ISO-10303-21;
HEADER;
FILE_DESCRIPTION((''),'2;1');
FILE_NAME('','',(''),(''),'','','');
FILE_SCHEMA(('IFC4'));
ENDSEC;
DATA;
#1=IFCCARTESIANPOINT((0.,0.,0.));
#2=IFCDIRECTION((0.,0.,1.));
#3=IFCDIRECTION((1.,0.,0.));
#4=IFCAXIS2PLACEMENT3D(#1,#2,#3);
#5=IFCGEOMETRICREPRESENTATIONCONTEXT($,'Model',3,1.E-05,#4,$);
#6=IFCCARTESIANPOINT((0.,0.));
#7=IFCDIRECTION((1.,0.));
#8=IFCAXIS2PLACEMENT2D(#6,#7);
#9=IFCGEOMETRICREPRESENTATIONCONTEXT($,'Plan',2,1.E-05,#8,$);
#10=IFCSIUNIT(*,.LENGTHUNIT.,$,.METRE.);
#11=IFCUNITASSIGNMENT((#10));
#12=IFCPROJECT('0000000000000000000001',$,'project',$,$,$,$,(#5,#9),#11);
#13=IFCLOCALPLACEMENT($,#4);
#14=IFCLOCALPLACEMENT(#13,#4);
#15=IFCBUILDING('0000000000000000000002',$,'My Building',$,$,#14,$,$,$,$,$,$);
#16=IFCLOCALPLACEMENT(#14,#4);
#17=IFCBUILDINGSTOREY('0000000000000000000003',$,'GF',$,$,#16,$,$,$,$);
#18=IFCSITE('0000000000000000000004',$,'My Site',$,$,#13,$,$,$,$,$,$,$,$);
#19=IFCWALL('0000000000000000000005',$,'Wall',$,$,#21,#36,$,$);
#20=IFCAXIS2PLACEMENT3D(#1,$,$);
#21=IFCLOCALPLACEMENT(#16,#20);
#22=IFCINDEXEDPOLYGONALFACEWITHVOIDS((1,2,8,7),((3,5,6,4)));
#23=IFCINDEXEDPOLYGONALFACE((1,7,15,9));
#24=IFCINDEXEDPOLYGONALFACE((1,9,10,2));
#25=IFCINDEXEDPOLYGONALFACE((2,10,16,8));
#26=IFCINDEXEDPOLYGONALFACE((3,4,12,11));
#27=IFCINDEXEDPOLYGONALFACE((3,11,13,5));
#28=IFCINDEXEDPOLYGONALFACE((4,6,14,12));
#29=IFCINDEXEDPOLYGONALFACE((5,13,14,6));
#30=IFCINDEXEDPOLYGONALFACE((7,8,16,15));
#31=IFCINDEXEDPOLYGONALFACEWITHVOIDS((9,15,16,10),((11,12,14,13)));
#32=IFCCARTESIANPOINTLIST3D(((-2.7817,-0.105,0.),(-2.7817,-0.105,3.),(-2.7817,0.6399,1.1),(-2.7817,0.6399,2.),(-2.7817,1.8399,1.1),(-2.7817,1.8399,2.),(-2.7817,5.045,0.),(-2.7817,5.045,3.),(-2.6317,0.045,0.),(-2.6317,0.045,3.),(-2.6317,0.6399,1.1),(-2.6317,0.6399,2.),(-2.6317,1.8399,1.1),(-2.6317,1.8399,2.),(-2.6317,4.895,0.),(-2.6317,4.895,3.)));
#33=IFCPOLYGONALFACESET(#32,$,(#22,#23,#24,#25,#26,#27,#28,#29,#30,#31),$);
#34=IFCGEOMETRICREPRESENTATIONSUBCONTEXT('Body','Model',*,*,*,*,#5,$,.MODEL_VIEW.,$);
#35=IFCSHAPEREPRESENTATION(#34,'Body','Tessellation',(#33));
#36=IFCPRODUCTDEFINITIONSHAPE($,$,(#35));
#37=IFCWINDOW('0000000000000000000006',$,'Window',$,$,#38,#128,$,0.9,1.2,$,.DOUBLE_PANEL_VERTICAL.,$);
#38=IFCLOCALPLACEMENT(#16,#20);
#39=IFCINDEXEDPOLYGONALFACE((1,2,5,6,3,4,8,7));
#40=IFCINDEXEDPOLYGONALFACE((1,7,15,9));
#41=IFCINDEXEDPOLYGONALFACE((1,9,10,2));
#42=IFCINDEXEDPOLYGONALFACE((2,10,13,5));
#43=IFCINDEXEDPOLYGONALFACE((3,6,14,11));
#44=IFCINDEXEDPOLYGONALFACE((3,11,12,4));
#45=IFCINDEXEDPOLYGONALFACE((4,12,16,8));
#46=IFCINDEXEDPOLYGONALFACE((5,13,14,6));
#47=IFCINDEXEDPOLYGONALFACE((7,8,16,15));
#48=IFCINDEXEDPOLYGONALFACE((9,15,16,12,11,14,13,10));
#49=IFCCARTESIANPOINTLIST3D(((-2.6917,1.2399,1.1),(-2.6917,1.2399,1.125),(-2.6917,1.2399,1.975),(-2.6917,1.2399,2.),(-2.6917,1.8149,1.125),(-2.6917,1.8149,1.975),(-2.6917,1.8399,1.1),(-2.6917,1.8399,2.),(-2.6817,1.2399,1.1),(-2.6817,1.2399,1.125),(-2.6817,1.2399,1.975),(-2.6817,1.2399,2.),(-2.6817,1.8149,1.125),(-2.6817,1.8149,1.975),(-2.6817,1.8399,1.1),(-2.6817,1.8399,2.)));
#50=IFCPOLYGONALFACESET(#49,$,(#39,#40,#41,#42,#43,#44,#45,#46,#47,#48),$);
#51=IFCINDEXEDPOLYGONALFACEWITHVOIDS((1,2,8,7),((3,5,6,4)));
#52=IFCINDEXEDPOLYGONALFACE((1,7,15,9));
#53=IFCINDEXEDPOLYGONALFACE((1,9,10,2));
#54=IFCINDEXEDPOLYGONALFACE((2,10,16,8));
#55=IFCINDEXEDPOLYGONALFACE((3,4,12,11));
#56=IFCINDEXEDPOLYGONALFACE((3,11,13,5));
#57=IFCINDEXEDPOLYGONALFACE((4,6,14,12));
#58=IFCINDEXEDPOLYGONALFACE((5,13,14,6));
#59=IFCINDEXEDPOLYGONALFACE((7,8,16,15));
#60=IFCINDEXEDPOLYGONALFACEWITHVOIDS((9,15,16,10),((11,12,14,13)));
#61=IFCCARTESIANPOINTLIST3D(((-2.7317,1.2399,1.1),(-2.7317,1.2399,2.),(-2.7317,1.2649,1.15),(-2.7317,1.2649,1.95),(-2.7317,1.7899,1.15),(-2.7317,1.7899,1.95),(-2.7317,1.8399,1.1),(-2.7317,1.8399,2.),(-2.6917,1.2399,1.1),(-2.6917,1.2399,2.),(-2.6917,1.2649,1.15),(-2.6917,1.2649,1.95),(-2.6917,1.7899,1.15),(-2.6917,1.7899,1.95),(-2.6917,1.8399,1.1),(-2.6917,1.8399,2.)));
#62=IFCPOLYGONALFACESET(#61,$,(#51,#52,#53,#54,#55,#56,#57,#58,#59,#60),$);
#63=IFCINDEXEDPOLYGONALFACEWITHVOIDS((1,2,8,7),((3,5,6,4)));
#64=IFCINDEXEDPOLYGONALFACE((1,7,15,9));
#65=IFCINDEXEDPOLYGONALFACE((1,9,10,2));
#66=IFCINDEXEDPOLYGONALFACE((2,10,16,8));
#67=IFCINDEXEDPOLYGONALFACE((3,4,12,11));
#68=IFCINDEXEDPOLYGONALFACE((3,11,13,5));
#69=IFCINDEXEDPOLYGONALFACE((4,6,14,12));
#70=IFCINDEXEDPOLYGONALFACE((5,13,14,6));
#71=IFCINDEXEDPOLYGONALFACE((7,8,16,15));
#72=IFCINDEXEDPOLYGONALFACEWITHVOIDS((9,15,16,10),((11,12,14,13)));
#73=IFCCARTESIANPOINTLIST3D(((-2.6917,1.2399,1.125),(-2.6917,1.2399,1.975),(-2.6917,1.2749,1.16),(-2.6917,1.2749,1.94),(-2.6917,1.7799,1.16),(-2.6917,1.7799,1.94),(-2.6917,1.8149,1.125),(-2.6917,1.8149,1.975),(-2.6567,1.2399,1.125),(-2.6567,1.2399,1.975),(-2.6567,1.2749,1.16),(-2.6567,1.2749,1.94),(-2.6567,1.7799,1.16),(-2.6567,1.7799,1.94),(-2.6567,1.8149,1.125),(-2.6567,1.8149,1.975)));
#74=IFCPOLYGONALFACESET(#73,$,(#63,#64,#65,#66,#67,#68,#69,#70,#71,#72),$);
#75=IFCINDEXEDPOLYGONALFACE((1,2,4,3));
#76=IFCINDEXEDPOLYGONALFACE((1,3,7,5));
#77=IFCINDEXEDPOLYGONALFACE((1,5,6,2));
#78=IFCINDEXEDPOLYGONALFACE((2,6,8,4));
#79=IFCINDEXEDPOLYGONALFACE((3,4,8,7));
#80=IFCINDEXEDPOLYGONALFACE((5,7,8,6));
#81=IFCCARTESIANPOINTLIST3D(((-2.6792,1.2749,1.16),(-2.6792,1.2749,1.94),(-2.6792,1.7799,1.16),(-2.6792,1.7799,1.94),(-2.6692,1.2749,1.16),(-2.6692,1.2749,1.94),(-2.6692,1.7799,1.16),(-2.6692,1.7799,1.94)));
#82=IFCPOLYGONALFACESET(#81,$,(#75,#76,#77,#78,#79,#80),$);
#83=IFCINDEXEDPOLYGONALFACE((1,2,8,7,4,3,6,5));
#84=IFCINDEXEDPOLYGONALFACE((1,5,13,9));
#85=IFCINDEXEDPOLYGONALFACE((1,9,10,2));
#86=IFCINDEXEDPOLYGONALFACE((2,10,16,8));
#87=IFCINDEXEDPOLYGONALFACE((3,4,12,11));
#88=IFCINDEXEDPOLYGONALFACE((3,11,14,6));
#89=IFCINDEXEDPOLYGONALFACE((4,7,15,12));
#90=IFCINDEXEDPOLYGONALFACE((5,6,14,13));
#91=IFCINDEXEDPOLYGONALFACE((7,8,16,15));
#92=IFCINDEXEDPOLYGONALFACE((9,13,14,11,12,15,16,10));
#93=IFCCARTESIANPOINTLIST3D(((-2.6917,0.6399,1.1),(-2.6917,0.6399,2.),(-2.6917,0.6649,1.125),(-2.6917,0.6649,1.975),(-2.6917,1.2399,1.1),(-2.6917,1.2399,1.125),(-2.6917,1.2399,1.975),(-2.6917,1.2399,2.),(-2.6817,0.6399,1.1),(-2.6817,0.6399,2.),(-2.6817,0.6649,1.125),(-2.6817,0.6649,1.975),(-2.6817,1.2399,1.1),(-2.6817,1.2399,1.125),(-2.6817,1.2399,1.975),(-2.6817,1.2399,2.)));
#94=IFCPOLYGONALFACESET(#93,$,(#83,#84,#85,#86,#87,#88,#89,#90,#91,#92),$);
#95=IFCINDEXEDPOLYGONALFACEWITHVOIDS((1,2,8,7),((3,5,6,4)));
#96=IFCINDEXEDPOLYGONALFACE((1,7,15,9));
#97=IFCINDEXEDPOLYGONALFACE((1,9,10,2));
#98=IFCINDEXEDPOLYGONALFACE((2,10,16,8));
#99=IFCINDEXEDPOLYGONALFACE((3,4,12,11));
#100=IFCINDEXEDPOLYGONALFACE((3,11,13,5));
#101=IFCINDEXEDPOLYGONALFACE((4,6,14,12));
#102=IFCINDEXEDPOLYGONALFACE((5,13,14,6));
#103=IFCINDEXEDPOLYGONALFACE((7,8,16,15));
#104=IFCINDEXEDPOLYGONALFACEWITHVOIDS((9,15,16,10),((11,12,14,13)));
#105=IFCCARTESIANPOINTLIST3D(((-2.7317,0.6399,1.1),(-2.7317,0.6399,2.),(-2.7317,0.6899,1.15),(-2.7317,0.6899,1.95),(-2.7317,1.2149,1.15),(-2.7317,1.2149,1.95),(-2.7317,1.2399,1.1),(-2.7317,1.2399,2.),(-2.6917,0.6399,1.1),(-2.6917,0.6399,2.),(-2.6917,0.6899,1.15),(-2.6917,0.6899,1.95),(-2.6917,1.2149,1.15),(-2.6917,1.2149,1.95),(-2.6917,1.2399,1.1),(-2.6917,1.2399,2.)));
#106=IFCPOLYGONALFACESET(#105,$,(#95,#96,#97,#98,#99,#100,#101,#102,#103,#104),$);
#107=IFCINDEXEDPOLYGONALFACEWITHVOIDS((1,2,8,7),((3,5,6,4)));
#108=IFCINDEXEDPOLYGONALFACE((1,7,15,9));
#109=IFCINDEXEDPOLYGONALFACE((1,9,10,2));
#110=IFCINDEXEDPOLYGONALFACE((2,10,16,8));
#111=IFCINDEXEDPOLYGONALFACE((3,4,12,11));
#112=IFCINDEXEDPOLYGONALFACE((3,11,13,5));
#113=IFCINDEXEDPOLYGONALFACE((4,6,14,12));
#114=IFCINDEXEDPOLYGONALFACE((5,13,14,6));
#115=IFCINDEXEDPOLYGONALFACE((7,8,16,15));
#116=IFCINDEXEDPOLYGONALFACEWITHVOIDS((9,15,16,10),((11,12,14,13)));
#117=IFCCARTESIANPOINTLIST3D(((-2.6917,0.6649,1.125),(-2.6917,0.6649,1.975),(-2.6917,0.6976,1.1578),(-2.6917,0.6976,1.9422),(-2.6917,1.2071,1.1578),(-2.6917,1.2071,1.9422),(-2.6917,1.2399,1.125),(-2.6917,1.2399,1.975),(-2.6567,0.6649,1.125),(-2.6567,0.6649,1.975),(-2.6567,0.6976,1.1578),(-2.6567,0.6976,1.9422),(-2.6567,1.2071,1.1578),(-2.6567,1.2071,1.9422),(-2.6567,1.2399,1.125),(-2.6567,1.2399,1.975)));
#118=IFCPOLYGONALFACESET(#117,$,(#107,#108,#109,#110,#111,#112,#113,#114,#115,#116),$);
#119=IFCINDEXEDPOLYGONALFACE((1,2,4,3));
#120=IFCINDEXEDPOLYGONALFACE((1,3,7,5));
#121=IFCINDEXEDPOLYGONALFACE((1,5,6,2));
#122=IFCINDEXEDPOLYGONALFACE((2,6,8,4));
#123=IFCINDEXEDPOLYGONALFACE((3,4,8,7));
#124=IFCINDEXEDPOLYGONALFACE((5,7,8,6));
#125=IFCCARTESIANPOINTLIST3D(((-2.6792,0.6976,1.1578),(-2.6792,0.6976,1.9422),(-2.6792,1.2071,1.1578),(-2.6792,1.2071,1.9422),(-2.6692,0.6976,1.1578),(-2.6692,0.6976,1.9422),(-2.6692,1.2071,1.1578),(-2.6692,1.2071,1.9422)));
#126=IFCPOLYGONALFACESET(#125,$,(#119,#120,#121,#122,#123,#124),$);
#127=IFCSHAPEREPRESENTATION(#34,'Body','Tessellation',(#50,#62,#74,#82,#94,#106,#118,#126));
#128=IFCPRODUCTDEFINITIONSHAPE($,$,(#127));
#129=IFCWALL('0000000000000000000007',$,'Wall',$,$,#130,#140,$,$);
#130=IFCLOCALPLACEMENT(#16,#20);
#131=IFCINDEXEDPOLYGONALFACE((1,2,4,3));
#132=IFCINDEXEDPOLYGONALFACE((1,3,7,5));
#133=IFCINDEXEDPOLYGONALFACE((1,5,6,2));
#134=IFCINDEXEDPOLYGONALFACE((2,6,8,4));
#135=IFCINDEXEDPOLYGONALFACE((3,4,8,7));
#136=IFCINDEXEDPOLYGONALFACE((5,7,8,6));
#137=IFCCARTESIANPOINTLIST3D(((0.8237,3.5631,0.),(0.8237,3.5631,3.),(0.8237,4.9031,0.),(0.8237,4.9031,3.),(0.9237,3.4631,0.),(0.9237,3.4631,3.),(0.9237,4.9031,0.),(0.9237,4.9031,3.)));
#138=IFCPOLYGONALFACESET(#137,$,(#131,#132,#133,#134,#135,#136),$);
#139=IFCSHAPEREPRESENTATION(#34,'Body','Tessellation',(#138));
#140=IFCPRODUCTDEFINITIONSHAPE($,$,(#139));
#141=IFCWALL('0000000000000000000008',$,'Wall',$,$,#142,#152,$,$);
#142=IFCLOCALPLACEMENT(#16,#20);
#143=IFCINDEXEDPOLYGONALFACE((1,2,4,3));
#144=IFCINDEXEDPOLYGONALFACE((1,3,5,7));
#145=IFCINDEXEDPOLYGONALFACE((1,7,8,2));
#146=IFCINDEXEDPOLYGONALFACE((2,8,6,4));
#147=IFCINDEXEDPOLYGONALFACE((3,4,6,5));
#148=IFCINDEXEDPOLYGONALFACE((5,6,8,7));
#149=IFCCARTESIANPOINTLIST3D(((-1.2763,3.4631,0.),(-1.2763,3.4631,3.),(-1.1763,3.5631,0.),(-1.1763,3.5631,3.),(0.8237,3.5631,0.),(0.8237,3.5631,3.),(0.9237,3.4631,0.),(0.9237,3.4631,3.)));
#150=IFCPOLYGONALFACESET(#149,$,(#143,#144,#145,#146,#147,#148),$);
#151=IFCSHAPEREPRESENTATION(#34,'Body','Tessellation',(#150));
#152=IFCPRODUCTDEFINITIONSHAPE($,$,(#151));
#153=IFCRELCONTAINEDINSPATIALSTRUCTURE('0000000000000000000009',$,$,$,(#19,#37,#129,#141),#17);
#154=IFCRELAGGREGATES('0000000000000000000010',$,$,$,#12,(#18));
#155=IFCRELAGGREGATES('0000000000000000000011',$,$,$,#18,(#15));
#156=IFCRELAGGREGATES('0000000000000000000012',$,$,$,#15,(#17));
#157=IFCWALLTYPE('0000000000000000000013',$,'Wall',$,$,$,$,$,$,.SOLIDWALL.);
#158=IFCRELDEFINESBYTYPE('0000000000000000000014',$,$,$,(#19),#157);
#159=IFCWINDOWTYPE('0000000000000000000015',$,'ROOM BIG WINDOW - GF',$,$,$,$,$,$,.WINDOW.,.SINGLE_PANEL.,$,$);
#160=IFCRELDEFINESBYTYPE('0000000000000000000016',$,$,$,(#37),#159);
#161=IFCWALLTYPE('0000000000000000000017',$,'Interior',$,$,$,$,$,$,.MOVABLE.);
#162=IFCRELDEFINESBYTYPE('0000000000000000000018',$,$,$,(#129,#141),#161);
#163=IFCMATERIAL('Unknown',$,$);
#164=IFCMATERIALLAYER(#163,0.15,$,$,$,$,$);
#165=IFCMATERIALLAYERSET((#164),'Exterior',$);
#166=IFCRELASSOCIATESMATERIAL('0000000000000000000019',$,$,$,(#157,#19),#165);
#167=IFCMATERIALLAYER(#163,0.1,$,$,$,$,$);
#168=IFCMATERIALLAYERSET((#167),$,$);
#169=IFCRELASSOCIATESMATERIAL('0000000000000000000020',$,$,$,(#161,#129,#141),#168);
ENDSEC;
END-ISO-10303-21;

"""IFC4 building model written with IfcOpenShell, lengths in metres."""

from ifc_helpers import new_model, entity, si_unit, frame, origin_with_axes, origin_2d_with_axis, place, context, subcontext, project, spatial, line, indexed_curve, outline, extrude, shape, source, transform, mapped, material, layer, layer_set, layer_usage, type_object, type_shapes, element, fill, save


model = new_model("IFC4")

# Units and contexts
model_context = context("Model", 3, precision=1e-05, world=origin_with_axes())
plan_context = context("Plan", 2, precision=1e-05, world=origin_2d_with_axis())
body_context_1 = subcontext(model_context, "Body", "Model", "MODEL_VIEW")
body_context_2 = subcontext(plan_context, "Body", "Plan", "PLAN_VIEW")
ifc_project = project(units=[si_unit("LENGTHUNIT", "METRE")], contexts=[model_context, plan_context])

# Site, building, storey
site_placement = place(None, origin_with_axes())
site = spatial("IfcSite", under=ifc_project, at=site_placement, Name="My Site")
building_placement = place(site_placement, origin_with_axes())
building = spatial("IfcBuilding", under=site, at=building_placement, Name="My Building")
storey_placement = place(building_placement, origin_with_axes())
storey = spatial("IfcBuildingStorey", under=building, at=storey_placement, Name="GF")

# Shared definitions
ifc_material = material(Name="Unknown")

# Shared definitions
ifc_layer_1 = layer(ifc_material, 0.15)
ifc_layer_set_1 = layer_set([ifc_layer_1], Name="Exterior")
wall_type_1 = type_object("IfcWallType", Name="Wall", PredefinedType="SOLIDWALL", material=ifc_layer_set_1)

# Wall, opening, window
ifc_layer_usage_1 = layer_usage(ifc_layer_set_1, "AXIS2", "POSITIVE", 0.0)
wall_1_placement = place(storey_placement, frame((-2.7817, 5.045, 0.0), z_axis=(0.0, 0.0, 1.0), x_axis=(0.0, -1.0, 0.0)))
wall_1 = element("IfcWall", 1, at=wall_1_placement, inside=storey, type_object=wall_type_1, material=ifc_layer_usage_1, Name="Wall", context=body_context_1, shape_type="SweptSolid", body=[
    extrude(outline(indexed_curve([(0.0, 0.0), (0.15, 0.15), (5.0, 0.15), (5.15, 0.0)], segments=[line(1, 2, 3, 4, 1)])), origin_with_axes(), (0.0, 0.0, 1.0), 3.0),
])
shared_shape_1 = source(origin_with_axes(), body_context_1, "Body", "SweptSolid", [
    extrude(outline(indexed_curve([(0.0, 0.0), (1.2, 0.0), (1.2, 0.9), (0.0, 0.9)], segments=[line(1, 2, 3, 4, 1)])), frame((0.0, -0.6, 0.0), z_axis=(0.0, -1.0, 0.0), x_axis=(1.0, 0.0, 0.0)), (0.0, 0.0, -1.0), 1.2),
])
opening_1_placement = place(wall_1_placement, frame((3.2051, 0.0, 1.1), z_axis=(0.0, 0.0, 1.0), x_axis=(1.0, 0.0, 0.0)))
opening_1 = element("IfcOpeningElement", 2, at=opening_1_placement, cuts=wall_1, PredefinedType="OPENING", context=body_context_1, shape_type="MappedRepresentation", body=[
    mapped(shared_shape_1, transform((0.0, 0.0, 0.0), x_axis=(1.0, 0.0, 0.0), y_axis=(0.0, 1.0, 0.0), z_axis=(0.0, 0.0, 1.0), scale=1.0)),
])
window_type_1 = type_object("IfcWindowType", Name="ROOM BIG WINDOW - GF", PartitioningType="SINGLE_PANEL", PredefinedType="WINDOW")
shared_shape_2 = source(origin_with_axes(), body_context_1, "Body", "SweptSolid", [
    extrude(outline(indexed_curve([(0.6, 0.0), (0.0, 0.0), (0.0, 0.9), (0.6, 0.9), (0.6, 0.875), (0.025, 0.875), (0.025, 0.025), (0.6, 0.025)], segments=[line(1, 2, 3, 4, 5, 6, 7, 8, 1)])), frame((0.0, 0.09, 0.0), z_axis=(0.0, -1.0, 0.0), x_axis=(1.0, 0.0, 0.0)), (0.0, 0.0, -1.0), 0.01),
    extrude(outline(indexed_curve([(0.0, 0.0), (0.6, 0.0), (0.6, 0.9), (0.0, 0.9)], segments=[line(1, 2, 3, 4, 1)]), holes=[indexed_curve([(0.05, 0.05), (0.575, 0.05), (0.575, 0.85), (0.05, 0.85)], segments=[line(1, 2, 3, 4, 1)])]), frame((0.0, 0.05, 0.0), z_axis=(0.0, -1.0, 0.0), x_axis=(1.0, 0.0, 0.0)), (0.0, 0.0, -1.0), 0.04),
    extrude(outline(indexed_curve([(0.0, 0.0), (0.575, 0.0), (0.575, 0.85), (0.0, 0.85)], segments=[line(1, 2, 3, 4, 1)]), holes=[indexed_curve([(0.035, 0.035), (0.54, 0.035), (0.54, 0.815), (0.035, 0.815)], segments=[line(1, 2, 3, 4, 1)])]), frame((0.025, 0.09, 0.025), z_axis=(0.0, -1.0, 0.0), x_axis=(1.0, 0.0, 0.0)), (0.0, 0.0, -1.0), 0.035),
    extrude(outline(indexed_curve([(0.035, 0.035), (0.54, 0.035), (0.54, 0.815), (0.035, 0.815)], segments=[line(1, 2, 3, 4, 1)])), frame((0.025, 0.1025, 0.025), z_axis=(0.0, -1.0, 0.0), x_axis=(1.0, 0.0, 0.0)), (0.0, 0.0, -1.0), 0.01),
    extrude(outline(indexed_curve([(0.0, 0.9), (0.6, 0.9), (0.6, 0.0), (0.0, 0.0), (0.0, 0.025), (0.575, 0.025), (0.575, 0.875), (0.0, 0.875)], segments=[line(1, 2, 3, 4, 5, 6, 7, 8, 1)])), frame((0.6, 0.09, 0.0), z_axis=(0.0, -1.0, 0.0), x_axis=(1.0, 0.0, 0.0)), (0.0, 0.0, -1.0), 0.01),
    extrude(outline(indexed_curve([(0.0, 0.0), (0.6, 0.0), (0.6, 0.9), (0.0, 0.9)], segments=[line(1, 2, 3, 4, 1)]), holes=[indexed_curve([(0.025, 0.05), (0.55, 0.05), (0.55, 0.85), (0.025, 0.85)], segments=[line(1, 2, 3, 4, 1)])]), frame((0.6, 0.05, 0.0), z_axis=(0.0, -1.0, 0.0), x_axis=(1.0, 0.0, 0.0)), (0.0, 0.0, -1.0), 0.04),
    extrude(outline(indexed_curve([(0.0, 0.0), (0.575, 0.0), (0.575, 0.85), (0.0, 0.85)], segments=[line(1, 2, 3, 4, 1)]), holes=[indexed_curve([(0.0328, 0.0328), (0.5422, 0.0328), (0.5422, 0.8172), (0.0328, 0.8172)], segments=[line(1, 2, 3, 4, 1)])]), frame((0.6, 0.09, 0.025), z_axis=(0.0, -1.0, 0.0), x_axis=(1.0, 0.0, 0.0)), (0.0, 0.0, -1.0), 0.035),
    extrude(outline(indexed_curve([(0.0328, 0.0328), (0.5422, 0.0328), (0.5422, 0.8172), (0.0328, 0.8172)], segments=[line(1, 2, 3, 4, 1)])), frame((0.6, 0.1025, 0.025), z_axis=(0.0, -1.0, 0.0), x_axis=(1.0, 0.0, 0.0)), (0.0, 0.0, -1.0), 0.01),
])
shared_shape_3 = source(origin_with_axes(), body_context_2, "Body", "Curve2D", [
    entity("IfcIndexedPolyCurve", entity("IfcCartesianPointList2D", [[0.05, 0.05], [0.575, 0.05]])),
    entity("IfcIndexedPolyCurve", entity("IfcCartesianPointList2D", [[0.0, 0.1], [0.025, 0.1], [0.025, 0.09], [0.05, 0.09], [0.05, 0.05], [0.0, 0.05]]), [entity("IfcLineIndex", [1, 2, 3, 4, 5, 6, 1])]),
    entity("IfcIndexedPolyCurve", entity("IfcCartesianPointList2D", [[0.6, 0.1], [0.6, 0.1], [0.6, 0.09], [0.575, 0.09], [0.575, 0.05], [0.6, 0.05]])),
    entity("IfcIndexedPolyCurve", entity("IfcCartesianPointList2D", [[0.025, 0.09], [0.06, 0.09], [0.06, 0.125], [0.025, 0.125]]), [entity("IfcLineIndex", [1, 2, 3, 4, 1])]),
    entity("IfcIndexedPolyCurve", entity("IfcCartesianPointList2D", [[0.6, 0.09], [0.565, 0.09], [0.565, 0.125], [0.6, 0.125]]), [entity("IfcLineIndex", [1, 2, 3, 4, 1])]),
    entity("IfcIndexedPolyCurve", entity("IfcCartesianPointList2D", [[0.06, 0.09], [0.565, 0.09]])),
    entity("IfcIndexedPolyCurve", entity("IfcCartesianPointList2D", [[0.06, 0.125], [0.565, 0.125]])),
    entity("IfcIndexedPolyCurve", entity("IfcCartesianPointList2D", [[0.06, 0.1075], [0.565, 0.1075]])),
    entity("IfcIndexedPolyCurve", entity("IfcCartesianPointList2D", [[0.625, 0.05], [1.15, 0.05]])),
    entity("IfcIndexedPolyCurve", entity("IfcCartesianPointList2D", [[0.6, 0.1], [0.6, 0.1], [0.6, 0.09], [0.625, 0.09], [0.625, 0.05], [0.6, 0.05]])),
    entity("IfcIndexedPolyCurve", entity("IfcCartesianPointList2D", [[1.2, 0.1], [1.175, 0.1], [1.175, 0.09], [1.15, 0.09], [1.15, 0.05], [1.2, 0.05]]), [entity("IfcLineIndex", [1, 2, 3, 4, 5, 6, 1])]),
    entity("IfcIndexedPolyCurve", entity("IfcCartesianPointList2D", [[0.6, 0.09], [0.6328, 0.09], [0.6328, 0.125], [0.6, 0.125]]), [entity("IfcLineIndex", [1, 2, 3, 4, 1])]),
    entity("IfcIndexedPolyCurve", entity("IfcCartesianPointList2D", [[1.175, 0.09], [1.1422, 0.09], [1.1422, 0.125], [1.175, 0.125]]), [entity("IfcLineIndex", [1, 2, 3, 4, 1])]),
    entity("IfcIndexedPolyCurve", entity("IfcCartesianPointList2D", [[0.6328, 0.09], [1.1422, 0.09]])),
    entity("IfcIndexedPolyCurve", entity("IfcCartesianPointList2D", [[0.6328, 0.125], [1.1422, 0.125]])),
    entity("IfcIndexedPolyCurve", entity("IfcCartesianPointList2D", [[0.6328, 0.1075], [1.1422, 0.1075]])),
])
type_shapes(window_type_1, [shared_shape_2, shared_shape_3])
window_1_placement = place(opening_1_placement, frame((0.0, 0.0, 0.0), z_axis=(0.0, 0.0, 1.0), x_axis=(1.0, 0.0, 0.0)))
window_1 = element("IfcWindow", 3, at=window_1_placement, inside=storey, type_object=window_type_1, Name="Window", OverallHeight=0.9, OverallWidth=1.2, PartitioningType="DOUBLE_PANEL_VERTICAL", shapes=[
    shape(body_context_1, "Body", "MappedRepresentation", [mapped(shared_shape_2, transform((0.0, 0.0, 0.0), x_axis=(1.0, 0.0, 0.0), y_axis=(0.0, 1.0, 0.0), z_axis=(0.0, 0.0, 1.0), scale=1.0))]),
    shape(body_context_2, "Body", "MappedRepresentation", [mapped(shared_shape_3, transform((0.0, 0.0, 0.0), x_axis=(1.0, 0.0, 0.0), y_axis=(0.0, 1.0, 0.0), z_axis=(0.0, 0.0, 1.0), scale=1.0))]),
])
fill(opening_1, window_1)

# Walls
ifc_layer_2 = layer(ifc_material, 0.1)
ifc_layer_set_2 = layer_set([ifc_layer_2])
ifc_layer_usage_2 = layer_usage(ifc_layer_set_2, "AXIS2", "POSITIVE", 0.0)
wall_type_2 = type_object("IfcWallType", Name="Interior", PredefinedType="MOVABLE", material=ifc_layer_set_2)
wall_2_placement = place(storey_placement, frame((0.8237, 4.9031, 0.0), z_axis=(0.0, 0.0, 1.0), x_axis=(0.0, -1.0, 0.0)))
element("IfcWall", 4, at=wall_2_placement, inside=storey, type_object=wall_type_2, material=ifc_layer_usage_2, Name="Wall", context=body_context_1, shape_type="SweptSolid", body=[
    extrude(outline(indexed_curve([(0.0, 0.0), (0.0, 0.1), (1.44, 0.1), (1.34, 0.0)], segments=[line(1, 2, 3, 4, 1)])), origin_with_axes(), (0.0, 0.0, 1.0), 3.0),
])
ifc_layer_usage_3 = layer_usage(ifc_layer_set_2, "AXIS2", "POSITIVE", 0.0)
wall_3_placement = place(storey_placement, frame((0.8237, 3.5631, 0.0), z_axis=(0.0, 0.0, 1.0), x_axis=(-1.0, 0.0, 0.0)))
element("IfcWall", 5, at=wall_3_placement, inside=storey, type_object=wall_type_2, material=ifc_layer_usage_3, Name="Wall", context=body_context_1, shape_type="SweptSolid", body=[
    extrude(outline(indexed_curve([(0.0, 0.0), (-0.1, 0.1), (2.1, 0.1), (2.0, 0.0)], segments=[line(1, 2, 3, 4, 1)])), origin_with_axes(), (0.0, 0.0, 1.0), 3.0),
])

save(model, "model.ifc")
